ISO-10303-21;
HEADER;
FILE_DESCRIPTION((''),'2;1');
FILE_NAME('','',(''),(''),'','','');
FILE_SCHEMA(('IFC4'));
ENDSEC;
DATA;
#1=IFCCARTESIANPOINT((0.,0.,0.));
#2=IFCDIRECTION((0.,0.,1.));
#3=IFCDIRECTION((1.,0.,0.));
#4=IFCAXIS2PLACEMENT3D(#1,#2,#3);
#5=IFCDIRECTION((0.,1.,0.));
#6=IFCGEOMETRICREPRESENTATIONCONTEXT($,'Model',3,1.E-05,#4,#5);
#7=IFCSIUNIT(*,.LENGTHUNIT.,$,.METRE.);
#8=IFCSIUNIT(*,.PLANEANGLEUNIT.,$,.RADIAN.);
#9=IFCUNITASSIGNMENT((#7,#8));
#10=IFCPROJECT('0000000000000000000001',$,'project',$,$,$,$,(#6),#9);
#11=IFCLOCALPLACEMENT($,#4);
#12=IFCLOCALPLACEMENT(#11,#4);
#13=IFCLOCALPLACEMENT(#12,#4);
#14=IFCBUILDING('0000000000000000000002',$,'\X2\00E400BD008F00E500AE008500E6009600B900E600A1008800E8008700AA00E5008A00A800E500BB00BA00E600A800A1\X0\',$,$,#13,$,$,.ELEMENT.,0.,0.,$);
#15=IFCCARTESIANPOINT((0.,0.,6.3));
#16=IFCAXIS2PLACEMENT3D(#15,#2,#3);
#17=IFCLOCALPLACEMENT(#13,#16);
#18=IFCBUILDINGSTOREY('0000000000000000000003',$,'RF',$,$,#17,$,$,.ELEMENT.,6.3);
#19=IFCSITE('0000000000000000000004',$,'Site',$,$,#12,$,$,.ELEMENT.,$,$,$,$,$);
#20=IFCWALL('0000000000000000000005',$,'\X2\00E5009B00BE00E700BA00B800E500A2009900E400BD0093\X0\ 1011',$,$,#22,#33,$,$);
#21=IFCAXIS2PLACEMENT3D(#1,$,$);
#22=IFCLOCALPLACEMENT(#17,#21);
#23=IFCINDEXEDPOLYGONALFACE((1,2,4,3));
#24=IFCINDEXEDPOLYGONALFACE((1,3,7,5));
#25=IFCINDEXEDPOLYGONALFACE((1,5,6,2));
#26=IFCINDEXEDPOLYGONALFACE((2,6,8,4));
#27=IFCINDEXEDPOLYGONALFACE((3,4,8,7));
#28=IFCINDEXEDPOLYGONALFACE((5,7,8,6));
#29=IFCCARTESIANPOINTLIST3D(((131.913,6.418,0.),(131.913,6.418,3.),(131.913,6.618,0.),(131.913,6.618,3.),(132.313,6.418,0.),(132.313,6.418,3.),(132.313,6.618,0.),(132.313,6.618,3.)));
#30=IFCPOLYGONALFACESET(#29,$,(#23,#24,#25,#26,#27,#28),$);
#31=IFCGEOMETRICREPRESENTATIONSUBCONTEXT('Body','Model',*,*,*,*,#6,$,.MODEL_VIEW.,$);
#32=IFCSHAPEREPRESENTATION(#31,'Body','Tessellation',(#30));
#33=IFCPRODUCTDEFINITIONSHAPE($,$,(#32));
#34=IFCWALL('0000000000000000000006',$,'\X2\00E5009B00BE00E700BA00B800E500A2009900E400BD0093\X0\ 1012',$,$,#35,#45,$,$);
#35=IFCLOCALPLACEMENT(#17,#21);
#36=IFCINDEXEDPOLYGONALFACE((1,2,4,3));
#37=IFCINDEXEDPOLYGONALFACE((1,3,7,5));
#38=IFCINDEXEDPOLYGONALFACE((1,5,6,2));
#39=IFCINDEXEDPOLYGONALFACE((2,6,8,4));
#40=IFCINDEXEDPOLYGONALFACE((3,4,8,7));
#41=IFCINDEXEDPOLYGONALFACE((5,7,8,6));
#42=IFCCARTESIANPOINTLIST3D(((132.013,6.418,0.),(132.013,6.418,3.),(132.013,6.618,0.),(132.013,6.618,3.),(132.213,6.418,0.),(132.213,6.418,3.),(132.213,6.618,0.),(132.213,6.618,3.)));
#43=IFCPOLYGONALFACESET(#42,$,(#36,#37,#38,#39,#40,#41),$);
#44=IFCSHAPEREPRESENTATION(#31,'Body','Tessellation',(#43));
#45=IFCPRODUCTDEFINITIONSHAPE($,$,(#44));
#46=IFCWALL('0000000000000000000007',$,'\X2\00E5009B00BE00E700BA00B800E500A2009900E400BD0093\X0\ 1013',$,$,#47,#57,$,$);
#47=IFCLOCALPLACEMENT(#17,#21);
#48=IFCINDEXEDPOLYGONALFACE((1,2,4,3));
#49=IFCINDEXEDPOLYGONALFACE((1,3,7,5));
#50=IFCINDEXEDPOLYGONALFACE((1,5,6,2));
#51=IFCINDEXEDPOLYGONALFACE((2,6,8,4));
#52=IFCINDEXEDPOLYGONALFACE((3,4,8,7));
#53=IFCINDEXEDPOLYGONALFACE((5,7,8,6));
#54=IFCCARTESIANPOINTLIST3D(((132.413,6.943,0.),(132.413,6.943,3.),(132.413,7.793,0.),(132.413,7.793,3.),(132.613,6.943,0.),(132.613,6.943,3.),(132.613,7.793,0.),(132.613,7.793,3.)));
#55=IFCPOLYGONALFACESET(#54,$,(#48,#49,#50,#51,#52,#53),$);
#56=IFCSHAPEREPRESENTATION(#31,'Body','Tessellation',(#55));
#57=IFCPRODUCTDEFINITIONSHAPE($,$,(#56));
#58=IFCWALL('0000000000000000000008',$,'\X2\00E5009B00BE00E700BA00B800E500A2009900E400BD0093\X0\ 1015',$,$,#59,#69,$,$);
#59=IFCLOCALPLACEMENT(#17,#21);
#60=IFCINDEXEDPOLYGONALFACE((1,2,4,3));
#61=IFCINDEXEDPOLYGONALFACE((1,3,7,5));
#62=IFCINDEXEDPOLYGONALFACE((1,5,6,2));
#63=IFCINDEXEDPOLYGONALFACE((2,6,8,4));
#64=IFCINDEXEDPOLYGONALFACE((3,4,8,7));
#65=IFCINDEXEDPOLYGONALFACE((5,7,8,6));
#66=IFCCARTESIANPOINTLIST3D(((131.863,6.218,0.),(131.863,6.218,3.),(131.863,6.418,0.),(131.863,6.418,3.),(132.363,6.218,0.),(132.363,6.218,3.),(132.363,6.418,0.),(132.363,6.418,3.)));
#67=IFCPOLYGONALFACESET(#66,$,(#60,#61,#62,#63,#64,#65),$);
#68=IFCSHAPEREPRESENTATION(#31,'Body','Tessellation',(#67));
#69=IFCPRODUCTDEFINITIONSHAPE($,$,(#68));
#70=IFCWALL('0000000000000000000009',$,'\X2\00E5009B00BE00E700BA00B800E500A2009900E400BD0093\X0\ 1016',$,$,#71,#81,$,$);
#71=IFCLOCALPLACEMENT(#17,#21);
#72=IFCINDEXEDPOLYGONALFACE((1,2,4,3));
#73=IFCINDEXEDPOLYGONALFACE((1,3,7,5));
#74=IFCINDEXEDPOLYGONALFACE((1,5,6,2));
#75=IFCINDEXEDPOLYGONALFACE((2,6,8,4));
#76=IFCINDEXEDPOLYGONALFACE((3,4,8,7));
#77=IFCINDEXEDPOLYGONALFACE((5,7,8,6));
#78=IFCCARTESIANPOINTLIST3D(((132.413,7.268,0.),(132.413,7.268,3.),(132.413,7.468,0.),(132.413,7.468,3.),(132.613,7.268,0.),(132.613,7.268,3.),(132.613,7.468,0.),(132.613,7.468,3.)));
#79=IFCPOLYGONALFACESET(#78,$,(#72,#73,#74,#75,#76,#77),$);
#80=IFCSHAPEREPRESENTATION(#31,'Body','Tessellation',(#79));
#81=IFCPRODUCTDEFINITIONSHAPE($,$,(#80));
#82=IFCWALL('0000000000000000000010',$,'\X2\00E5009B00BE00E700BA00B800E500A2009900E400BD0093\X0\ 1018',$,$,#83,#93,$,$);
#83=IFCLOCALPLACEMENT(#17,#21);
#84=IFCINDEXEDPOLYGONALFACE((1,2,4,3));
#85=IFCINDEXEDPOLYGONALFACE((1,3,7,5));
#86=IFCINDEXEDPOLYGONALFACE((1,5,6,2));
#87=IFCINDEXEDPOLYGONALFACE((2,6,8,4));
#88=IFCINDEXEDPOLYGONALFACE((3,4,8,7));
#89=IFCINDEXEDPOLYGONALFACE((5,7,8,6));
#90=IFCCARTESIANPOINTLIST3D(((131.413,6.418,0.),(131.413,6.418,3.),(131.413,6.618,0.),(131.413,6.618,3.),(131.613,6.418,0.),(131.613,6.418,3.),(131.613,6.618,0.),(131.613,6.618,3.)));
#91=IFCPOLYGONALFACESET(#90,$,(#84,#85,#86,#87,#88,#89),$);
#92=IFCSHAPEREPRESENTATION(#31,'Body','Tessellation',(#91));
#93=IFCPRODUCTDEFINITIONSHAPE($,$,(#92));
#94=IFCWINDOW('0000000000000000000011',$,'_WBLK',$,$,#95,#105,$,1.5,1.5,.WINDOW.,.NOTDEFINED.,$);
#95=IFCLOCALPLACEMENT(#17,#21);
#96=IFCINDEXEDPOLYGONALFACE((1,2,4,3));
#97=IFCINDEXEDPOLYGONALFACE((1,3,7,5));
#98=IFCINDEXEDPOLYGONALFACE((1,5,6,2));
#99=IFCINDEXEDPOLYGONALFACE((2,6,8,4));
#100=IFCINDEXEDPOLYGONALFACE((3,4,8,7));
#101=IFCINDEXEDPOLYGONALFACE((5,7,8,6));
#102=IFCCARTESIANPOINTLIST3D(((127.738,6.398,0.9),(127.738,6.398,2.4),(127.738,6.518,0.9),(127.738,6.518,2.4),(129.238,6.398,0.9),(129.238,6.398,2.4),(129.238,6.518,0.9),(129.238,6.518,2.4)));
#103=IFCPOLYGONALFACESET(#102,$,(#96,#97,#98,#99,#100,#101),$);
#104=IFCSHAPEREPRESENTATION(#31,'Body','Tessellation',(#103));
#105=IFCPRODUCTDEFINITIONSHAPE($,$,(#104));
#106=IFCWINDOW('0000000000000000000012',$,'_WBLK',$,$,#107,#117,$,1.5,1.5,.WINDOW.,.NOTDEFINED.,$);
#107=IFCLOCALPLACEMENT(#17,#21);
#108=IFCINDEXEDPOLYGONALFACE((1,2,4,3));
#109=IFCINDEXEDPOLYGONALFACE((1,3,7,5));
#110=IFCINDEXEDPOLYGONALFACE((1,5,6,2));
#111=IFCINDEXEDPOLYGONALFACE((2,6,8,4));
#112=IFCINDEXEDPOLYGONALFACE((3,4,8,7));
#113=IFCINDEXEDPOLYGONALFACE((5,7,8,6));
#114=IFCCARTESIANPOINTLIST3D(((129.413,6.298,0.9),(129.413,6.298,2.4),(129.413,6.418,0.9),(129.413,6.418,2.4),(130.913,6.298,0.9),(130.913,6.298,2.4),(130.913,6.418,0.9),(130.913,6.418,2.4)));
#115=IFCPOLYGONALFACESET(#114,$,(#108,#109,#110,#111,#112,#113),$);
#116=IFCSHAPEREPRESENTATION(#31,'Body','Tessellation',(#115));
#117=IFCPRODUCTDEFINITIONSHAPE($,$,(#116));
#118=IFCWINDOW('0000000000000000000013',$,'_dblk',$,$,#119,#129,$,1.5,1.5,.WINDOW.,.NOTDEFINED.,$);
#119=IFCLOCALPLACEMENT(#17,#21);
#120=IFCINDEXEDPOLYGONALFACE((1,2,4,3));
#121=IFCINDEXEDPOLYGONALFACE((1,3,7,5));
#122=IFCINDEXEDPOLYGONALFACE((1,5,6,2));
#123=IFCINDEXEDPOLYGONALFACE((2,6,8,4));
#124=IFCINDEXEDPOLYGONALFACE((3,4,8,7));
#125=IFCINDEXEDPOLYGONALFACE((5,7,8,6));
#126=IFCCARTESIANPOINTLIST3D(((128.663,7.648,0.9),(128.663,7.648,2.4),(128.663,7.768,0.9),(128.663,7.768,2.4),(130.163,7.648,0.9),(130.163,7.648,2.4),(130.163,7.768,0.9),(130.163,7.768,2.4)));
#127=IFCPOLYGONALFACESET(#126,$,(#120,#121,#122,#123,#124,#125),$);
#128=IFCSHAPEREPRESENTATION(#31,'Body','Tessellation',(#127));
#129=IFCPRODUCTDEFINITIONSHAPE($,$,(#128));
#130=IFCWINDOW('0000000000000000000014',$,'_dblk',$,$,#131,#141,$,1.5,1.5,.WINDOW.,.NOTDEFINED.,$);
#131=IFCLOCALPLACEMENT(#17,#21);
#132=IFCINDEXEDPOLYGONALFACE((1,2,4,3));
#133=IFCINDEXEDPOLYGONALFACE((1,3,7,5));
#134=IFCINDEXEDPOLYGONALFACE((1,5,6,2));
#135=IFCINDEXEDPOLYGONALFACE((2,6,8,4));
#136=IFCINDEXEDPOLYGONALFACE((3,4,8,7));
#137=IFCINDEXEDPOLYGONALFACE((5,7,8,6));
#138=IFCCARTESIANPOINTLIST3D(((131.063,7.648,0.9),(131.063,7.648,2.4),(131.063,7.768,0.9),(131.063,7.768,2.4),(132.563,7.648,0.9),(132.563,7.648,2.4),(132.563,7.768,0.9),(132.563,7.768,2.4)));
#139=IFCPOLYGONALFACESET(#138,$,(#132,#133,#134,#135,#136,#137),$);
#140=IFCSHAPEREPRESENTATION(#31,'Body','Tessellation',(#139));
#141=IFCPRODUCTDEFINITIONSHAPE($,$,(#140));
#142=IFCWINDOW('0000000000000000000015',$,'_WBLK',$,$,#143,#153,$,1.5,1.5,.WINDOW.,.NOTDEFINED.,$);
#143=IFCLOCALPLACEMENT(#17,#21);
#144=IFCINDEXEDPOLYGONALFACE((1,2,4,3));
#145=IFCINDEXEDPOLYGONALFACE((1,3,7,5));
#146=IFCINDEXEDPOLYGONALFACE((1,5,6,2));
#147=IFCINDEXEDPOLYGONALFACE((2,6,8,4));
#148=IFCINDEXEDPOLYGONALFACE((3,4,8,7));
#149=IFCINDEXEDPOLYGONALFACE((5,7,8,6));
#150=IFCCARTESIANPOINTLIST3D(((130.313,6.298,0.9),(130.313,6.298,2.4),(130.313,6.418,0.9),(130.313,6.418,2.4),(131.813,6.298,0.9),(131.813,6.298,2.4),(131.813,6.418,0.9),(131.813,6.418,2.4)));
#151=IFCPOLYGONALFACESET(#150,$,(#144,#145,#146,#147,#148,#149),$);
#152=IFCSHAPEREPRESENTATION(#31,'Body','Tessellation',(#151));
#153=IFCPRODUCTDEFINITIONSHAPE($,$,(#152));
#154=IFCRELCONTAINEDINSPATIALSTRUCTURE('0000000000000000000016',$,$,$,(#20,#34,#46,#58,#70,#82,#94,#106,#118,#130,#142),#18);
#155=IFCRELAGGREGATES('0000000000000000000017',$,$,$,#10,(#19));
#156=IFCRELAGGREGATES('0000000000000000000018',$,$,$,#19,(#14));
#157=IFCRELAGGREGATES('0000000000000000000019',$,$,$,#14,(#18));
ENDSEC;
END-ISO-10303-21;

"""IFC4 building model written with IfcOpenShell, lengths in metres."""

from ifc_helpers import new_model, si_unit, direction, frame, frame_2d, origin_with_axes, place, context, subcontext, project, spatial, rectangle, extrude, element, save


model = new_model("IFC4")

# Units and contexts
model_context = context("Model", 3, precision=1e-05, world=origin_with_axes(), true_north=direction((0.0, 1.0, 0.0)))
body_context = subcontext(model_context, "Body", "Model", "MODEL_VIEW")
ifc_project = project(units=[si_unit("LENGTHUNIT", "METRE"), si_unit("PLANEANGLEUNIT", "RADIAN")], contexts=[model_context])

# Site, building, storey
placement = place(None, origin_with_axes())
site_placement = place(placement, origin_with_axes())
site = spatial("IfcSite", under=ifc_project, at=site_placement, Name="Site", CompositionType="ELEMENT")
building_placement = place(site_placement, origin_with_axes())
building = spatial("IfcBuilding", under=site, at=building_placement, Name="ä½\u008få®\u0085æ\u0096¹æ¡\u0088è\u0087ªå\u008a¨å»ºæ¨¡", CompositionType="ELEMENT", ElevationOfRefHeight=0.0, ElevationOfTerrain=0.0)
storey_placement = place(building_placement, frame((0.0, 0.0, 6.3), z_axis=(0.0, 0.0, 1.0), x_axis=(1.0, 0.0, 0.0)))
storey = spatial("IfcBuildingStorey", under=building, at=storey_placement, Name="RF", CompositionType="ELEMENT", Elevation=6.3)

# Walls
for number, where, z_axis, x_axis, name in (
    (1, (132.113, 6.518, 0.0), (0.0, 0.0, 1.0), (1.0, 0.0, 0.0), "å\u009b¾çº¸å¢\u0099ä½\u0093 1011"),
):
    element("IfcWall", number, at=place(storey_placement, frame(where, z_axis=z_axis, x_axis=x_axis)), inside=storey, Name=name, context=body_context, shape_type="SweptSolid", body=[
        extrude(rectangle(XDim=0.4, YDim=0.2, at=frame_2d((0.0, 0.0), x_axis=(1.0, 0.0, 0.0))), frame((0.0, 0.0, 0.0), z_axis=(0.0, 0.0, 1.0)), (0.0, 0.0, 1.0), 3.0),
    ])
wall_1_placement = place(storey_placement, frame((132.113, 6.518, 0.0), z_axis=(0.0, 0.0, 1.0), x_axis=(0.0, -1.0, 0.0)))
element("IfcWall", 2, at=wall_1_placement, inside=storey, Name="å\u009b¾çº¸å¢\u0099ä½\u0093 1012", context=body_context, shape_type="SweptSolid", body=[
    extrude(rectangle(XDim=0.2, YDim=0.2, at=frame_2d((0.0, 0.0), x_axis=(1.0, 0.0, 0.0))), frame((0.0, 0.0, 0.0), z_axis=(0.0, 0.0, 1.0)), (0.0, 0.0, 1.0), 3.0),
])
wall_2_placement = place(storey_placement, frame((132.513, 7.368, 0.0), z_axis=(0.0, 0.0, 1.0), x_axis=(0.0, -1.0, 0.0)))
element("IfcWall", 3, at=wall_2_placement, inside=storey, Name="å\u009b¾çº¸å¢\u0099ä½\u0093 1013", context=body_context, shape_type="SweptSolid", body=[
    extrude(rectangle(XDim=0.85, YDim=0.2, at=frame_2d((0.0, 0.0), x_axis=(1.0, 0.0, 0.0))), frame((0.0, 0.0, 0.0), z_axis=(0.0, 0.0, 1.0)), (0.0, 0.0, 1.0), 3.0),
])
wall_3_placement = place(storey_placement, frame((132.113, 6.318, 0.0), z_axis=(0.0, 0.0, 1.0), x_axis=(1.0, 0.0, 0.0)))
element("IfcWall", 4, at=wall_3_placement, inside=storey, Name="å\u009b¾çº¸å¢\u0099ä½\u0093 1015", context=body_context, shape_type="SweptSolid", body=[
    extrude(rectangle(XDim=0.5, YDim=0.2, at=frame_2d((0.0, 0.0), x_axis=(1.0, 0.0, 0.0))), frame((0.0, 0.0, 0.0), z_axis=(0.0, 0.0, 1.0)), (0.0, 0.0, 1.0), 3.0),
])
for number, where, z_axis, x_axis, name in (
    (5, (132.513, 7.368, 0.0), (0.0, 0.0, 1.0), (1.0, 0.0, 0.0), "å\u009b¾çº¸å¢\u0099ä½\u0093 1016"),
    (6, (131.513, 6.518, 0.0), (0.0, 0.0, 1.0), (0.0, -1.0, 0.0), "å\u009b¾çº¸å¢\u0099ä½\u0093 1018"),
):
    element("IfcWall", number, at=place(storey_placement, frame(where, z_axis=z_axis, x_axis=x_axis)), inside=storey, Name=name, context=body_context, shape_type="SweptSolid", body=[
        extrude(rectangle(XDim=0.2, YDim=0.2, at=frame_2d((0.0, 0.0), x_axis=(1.0, 0.0, 0.0))), frame((0.0, 0.0, 0.0), z_axis=(0.0, 0.0, 1.0)), (0.0, 0.0, 1.0), 3.0),
    ])

# Windows
for number, where, z_axis, x_axis, name in (
    (7, (128.488, 6.458, 0.9), (0.0, 0.0, 1.0), (1.0, 0.0, 0.0), "_WBLK"),
    (8, (130.163, 6.358, 0.9), (0.0, 0.0, 1.0), (1.0, 0.0, 0.0), "_WBLK"),
    (9, (129.413, 7.708, 0.9), (0.0, 0.0, 1.0), (1.0, 0.0, 0.0), "_dblk"),
    (10, (131.813, 7.708, 0.9), (0.0, 0.0, 1.0), (1.0, 0.0, 0.0), "_dblk"),
    (11, (131.063, 6.358, 0.9), (0.0, 0.0, 1.0), (1.0, 0.0, 0.0), "_WBLK"),
):
    element("IfcWindow", number, at=place(storey_placement, frame(where, z_axis=z_axis, x_axis=x_axis)), inside=storey, Name=name, OverallHeight=1.5, OverallWidth=1.5, PartitioningType="NOTDEFINED", PredefinedType="WINDOW", context=body_context, shape_type="SweptSolid", body=[
        extrude(rectangle(XDim=1.5, YDim=0.12, at=frame_2d((0.0, 0.0), x_axis=(1.0, 0.0, 0.0))), frame((0.0, 0.0, 0.0), z_axis=(0.0, 0.0, 1.0)), (0.0, 0.0, 1.0), 1.5),
    ])

save(model, "model.ifc")
